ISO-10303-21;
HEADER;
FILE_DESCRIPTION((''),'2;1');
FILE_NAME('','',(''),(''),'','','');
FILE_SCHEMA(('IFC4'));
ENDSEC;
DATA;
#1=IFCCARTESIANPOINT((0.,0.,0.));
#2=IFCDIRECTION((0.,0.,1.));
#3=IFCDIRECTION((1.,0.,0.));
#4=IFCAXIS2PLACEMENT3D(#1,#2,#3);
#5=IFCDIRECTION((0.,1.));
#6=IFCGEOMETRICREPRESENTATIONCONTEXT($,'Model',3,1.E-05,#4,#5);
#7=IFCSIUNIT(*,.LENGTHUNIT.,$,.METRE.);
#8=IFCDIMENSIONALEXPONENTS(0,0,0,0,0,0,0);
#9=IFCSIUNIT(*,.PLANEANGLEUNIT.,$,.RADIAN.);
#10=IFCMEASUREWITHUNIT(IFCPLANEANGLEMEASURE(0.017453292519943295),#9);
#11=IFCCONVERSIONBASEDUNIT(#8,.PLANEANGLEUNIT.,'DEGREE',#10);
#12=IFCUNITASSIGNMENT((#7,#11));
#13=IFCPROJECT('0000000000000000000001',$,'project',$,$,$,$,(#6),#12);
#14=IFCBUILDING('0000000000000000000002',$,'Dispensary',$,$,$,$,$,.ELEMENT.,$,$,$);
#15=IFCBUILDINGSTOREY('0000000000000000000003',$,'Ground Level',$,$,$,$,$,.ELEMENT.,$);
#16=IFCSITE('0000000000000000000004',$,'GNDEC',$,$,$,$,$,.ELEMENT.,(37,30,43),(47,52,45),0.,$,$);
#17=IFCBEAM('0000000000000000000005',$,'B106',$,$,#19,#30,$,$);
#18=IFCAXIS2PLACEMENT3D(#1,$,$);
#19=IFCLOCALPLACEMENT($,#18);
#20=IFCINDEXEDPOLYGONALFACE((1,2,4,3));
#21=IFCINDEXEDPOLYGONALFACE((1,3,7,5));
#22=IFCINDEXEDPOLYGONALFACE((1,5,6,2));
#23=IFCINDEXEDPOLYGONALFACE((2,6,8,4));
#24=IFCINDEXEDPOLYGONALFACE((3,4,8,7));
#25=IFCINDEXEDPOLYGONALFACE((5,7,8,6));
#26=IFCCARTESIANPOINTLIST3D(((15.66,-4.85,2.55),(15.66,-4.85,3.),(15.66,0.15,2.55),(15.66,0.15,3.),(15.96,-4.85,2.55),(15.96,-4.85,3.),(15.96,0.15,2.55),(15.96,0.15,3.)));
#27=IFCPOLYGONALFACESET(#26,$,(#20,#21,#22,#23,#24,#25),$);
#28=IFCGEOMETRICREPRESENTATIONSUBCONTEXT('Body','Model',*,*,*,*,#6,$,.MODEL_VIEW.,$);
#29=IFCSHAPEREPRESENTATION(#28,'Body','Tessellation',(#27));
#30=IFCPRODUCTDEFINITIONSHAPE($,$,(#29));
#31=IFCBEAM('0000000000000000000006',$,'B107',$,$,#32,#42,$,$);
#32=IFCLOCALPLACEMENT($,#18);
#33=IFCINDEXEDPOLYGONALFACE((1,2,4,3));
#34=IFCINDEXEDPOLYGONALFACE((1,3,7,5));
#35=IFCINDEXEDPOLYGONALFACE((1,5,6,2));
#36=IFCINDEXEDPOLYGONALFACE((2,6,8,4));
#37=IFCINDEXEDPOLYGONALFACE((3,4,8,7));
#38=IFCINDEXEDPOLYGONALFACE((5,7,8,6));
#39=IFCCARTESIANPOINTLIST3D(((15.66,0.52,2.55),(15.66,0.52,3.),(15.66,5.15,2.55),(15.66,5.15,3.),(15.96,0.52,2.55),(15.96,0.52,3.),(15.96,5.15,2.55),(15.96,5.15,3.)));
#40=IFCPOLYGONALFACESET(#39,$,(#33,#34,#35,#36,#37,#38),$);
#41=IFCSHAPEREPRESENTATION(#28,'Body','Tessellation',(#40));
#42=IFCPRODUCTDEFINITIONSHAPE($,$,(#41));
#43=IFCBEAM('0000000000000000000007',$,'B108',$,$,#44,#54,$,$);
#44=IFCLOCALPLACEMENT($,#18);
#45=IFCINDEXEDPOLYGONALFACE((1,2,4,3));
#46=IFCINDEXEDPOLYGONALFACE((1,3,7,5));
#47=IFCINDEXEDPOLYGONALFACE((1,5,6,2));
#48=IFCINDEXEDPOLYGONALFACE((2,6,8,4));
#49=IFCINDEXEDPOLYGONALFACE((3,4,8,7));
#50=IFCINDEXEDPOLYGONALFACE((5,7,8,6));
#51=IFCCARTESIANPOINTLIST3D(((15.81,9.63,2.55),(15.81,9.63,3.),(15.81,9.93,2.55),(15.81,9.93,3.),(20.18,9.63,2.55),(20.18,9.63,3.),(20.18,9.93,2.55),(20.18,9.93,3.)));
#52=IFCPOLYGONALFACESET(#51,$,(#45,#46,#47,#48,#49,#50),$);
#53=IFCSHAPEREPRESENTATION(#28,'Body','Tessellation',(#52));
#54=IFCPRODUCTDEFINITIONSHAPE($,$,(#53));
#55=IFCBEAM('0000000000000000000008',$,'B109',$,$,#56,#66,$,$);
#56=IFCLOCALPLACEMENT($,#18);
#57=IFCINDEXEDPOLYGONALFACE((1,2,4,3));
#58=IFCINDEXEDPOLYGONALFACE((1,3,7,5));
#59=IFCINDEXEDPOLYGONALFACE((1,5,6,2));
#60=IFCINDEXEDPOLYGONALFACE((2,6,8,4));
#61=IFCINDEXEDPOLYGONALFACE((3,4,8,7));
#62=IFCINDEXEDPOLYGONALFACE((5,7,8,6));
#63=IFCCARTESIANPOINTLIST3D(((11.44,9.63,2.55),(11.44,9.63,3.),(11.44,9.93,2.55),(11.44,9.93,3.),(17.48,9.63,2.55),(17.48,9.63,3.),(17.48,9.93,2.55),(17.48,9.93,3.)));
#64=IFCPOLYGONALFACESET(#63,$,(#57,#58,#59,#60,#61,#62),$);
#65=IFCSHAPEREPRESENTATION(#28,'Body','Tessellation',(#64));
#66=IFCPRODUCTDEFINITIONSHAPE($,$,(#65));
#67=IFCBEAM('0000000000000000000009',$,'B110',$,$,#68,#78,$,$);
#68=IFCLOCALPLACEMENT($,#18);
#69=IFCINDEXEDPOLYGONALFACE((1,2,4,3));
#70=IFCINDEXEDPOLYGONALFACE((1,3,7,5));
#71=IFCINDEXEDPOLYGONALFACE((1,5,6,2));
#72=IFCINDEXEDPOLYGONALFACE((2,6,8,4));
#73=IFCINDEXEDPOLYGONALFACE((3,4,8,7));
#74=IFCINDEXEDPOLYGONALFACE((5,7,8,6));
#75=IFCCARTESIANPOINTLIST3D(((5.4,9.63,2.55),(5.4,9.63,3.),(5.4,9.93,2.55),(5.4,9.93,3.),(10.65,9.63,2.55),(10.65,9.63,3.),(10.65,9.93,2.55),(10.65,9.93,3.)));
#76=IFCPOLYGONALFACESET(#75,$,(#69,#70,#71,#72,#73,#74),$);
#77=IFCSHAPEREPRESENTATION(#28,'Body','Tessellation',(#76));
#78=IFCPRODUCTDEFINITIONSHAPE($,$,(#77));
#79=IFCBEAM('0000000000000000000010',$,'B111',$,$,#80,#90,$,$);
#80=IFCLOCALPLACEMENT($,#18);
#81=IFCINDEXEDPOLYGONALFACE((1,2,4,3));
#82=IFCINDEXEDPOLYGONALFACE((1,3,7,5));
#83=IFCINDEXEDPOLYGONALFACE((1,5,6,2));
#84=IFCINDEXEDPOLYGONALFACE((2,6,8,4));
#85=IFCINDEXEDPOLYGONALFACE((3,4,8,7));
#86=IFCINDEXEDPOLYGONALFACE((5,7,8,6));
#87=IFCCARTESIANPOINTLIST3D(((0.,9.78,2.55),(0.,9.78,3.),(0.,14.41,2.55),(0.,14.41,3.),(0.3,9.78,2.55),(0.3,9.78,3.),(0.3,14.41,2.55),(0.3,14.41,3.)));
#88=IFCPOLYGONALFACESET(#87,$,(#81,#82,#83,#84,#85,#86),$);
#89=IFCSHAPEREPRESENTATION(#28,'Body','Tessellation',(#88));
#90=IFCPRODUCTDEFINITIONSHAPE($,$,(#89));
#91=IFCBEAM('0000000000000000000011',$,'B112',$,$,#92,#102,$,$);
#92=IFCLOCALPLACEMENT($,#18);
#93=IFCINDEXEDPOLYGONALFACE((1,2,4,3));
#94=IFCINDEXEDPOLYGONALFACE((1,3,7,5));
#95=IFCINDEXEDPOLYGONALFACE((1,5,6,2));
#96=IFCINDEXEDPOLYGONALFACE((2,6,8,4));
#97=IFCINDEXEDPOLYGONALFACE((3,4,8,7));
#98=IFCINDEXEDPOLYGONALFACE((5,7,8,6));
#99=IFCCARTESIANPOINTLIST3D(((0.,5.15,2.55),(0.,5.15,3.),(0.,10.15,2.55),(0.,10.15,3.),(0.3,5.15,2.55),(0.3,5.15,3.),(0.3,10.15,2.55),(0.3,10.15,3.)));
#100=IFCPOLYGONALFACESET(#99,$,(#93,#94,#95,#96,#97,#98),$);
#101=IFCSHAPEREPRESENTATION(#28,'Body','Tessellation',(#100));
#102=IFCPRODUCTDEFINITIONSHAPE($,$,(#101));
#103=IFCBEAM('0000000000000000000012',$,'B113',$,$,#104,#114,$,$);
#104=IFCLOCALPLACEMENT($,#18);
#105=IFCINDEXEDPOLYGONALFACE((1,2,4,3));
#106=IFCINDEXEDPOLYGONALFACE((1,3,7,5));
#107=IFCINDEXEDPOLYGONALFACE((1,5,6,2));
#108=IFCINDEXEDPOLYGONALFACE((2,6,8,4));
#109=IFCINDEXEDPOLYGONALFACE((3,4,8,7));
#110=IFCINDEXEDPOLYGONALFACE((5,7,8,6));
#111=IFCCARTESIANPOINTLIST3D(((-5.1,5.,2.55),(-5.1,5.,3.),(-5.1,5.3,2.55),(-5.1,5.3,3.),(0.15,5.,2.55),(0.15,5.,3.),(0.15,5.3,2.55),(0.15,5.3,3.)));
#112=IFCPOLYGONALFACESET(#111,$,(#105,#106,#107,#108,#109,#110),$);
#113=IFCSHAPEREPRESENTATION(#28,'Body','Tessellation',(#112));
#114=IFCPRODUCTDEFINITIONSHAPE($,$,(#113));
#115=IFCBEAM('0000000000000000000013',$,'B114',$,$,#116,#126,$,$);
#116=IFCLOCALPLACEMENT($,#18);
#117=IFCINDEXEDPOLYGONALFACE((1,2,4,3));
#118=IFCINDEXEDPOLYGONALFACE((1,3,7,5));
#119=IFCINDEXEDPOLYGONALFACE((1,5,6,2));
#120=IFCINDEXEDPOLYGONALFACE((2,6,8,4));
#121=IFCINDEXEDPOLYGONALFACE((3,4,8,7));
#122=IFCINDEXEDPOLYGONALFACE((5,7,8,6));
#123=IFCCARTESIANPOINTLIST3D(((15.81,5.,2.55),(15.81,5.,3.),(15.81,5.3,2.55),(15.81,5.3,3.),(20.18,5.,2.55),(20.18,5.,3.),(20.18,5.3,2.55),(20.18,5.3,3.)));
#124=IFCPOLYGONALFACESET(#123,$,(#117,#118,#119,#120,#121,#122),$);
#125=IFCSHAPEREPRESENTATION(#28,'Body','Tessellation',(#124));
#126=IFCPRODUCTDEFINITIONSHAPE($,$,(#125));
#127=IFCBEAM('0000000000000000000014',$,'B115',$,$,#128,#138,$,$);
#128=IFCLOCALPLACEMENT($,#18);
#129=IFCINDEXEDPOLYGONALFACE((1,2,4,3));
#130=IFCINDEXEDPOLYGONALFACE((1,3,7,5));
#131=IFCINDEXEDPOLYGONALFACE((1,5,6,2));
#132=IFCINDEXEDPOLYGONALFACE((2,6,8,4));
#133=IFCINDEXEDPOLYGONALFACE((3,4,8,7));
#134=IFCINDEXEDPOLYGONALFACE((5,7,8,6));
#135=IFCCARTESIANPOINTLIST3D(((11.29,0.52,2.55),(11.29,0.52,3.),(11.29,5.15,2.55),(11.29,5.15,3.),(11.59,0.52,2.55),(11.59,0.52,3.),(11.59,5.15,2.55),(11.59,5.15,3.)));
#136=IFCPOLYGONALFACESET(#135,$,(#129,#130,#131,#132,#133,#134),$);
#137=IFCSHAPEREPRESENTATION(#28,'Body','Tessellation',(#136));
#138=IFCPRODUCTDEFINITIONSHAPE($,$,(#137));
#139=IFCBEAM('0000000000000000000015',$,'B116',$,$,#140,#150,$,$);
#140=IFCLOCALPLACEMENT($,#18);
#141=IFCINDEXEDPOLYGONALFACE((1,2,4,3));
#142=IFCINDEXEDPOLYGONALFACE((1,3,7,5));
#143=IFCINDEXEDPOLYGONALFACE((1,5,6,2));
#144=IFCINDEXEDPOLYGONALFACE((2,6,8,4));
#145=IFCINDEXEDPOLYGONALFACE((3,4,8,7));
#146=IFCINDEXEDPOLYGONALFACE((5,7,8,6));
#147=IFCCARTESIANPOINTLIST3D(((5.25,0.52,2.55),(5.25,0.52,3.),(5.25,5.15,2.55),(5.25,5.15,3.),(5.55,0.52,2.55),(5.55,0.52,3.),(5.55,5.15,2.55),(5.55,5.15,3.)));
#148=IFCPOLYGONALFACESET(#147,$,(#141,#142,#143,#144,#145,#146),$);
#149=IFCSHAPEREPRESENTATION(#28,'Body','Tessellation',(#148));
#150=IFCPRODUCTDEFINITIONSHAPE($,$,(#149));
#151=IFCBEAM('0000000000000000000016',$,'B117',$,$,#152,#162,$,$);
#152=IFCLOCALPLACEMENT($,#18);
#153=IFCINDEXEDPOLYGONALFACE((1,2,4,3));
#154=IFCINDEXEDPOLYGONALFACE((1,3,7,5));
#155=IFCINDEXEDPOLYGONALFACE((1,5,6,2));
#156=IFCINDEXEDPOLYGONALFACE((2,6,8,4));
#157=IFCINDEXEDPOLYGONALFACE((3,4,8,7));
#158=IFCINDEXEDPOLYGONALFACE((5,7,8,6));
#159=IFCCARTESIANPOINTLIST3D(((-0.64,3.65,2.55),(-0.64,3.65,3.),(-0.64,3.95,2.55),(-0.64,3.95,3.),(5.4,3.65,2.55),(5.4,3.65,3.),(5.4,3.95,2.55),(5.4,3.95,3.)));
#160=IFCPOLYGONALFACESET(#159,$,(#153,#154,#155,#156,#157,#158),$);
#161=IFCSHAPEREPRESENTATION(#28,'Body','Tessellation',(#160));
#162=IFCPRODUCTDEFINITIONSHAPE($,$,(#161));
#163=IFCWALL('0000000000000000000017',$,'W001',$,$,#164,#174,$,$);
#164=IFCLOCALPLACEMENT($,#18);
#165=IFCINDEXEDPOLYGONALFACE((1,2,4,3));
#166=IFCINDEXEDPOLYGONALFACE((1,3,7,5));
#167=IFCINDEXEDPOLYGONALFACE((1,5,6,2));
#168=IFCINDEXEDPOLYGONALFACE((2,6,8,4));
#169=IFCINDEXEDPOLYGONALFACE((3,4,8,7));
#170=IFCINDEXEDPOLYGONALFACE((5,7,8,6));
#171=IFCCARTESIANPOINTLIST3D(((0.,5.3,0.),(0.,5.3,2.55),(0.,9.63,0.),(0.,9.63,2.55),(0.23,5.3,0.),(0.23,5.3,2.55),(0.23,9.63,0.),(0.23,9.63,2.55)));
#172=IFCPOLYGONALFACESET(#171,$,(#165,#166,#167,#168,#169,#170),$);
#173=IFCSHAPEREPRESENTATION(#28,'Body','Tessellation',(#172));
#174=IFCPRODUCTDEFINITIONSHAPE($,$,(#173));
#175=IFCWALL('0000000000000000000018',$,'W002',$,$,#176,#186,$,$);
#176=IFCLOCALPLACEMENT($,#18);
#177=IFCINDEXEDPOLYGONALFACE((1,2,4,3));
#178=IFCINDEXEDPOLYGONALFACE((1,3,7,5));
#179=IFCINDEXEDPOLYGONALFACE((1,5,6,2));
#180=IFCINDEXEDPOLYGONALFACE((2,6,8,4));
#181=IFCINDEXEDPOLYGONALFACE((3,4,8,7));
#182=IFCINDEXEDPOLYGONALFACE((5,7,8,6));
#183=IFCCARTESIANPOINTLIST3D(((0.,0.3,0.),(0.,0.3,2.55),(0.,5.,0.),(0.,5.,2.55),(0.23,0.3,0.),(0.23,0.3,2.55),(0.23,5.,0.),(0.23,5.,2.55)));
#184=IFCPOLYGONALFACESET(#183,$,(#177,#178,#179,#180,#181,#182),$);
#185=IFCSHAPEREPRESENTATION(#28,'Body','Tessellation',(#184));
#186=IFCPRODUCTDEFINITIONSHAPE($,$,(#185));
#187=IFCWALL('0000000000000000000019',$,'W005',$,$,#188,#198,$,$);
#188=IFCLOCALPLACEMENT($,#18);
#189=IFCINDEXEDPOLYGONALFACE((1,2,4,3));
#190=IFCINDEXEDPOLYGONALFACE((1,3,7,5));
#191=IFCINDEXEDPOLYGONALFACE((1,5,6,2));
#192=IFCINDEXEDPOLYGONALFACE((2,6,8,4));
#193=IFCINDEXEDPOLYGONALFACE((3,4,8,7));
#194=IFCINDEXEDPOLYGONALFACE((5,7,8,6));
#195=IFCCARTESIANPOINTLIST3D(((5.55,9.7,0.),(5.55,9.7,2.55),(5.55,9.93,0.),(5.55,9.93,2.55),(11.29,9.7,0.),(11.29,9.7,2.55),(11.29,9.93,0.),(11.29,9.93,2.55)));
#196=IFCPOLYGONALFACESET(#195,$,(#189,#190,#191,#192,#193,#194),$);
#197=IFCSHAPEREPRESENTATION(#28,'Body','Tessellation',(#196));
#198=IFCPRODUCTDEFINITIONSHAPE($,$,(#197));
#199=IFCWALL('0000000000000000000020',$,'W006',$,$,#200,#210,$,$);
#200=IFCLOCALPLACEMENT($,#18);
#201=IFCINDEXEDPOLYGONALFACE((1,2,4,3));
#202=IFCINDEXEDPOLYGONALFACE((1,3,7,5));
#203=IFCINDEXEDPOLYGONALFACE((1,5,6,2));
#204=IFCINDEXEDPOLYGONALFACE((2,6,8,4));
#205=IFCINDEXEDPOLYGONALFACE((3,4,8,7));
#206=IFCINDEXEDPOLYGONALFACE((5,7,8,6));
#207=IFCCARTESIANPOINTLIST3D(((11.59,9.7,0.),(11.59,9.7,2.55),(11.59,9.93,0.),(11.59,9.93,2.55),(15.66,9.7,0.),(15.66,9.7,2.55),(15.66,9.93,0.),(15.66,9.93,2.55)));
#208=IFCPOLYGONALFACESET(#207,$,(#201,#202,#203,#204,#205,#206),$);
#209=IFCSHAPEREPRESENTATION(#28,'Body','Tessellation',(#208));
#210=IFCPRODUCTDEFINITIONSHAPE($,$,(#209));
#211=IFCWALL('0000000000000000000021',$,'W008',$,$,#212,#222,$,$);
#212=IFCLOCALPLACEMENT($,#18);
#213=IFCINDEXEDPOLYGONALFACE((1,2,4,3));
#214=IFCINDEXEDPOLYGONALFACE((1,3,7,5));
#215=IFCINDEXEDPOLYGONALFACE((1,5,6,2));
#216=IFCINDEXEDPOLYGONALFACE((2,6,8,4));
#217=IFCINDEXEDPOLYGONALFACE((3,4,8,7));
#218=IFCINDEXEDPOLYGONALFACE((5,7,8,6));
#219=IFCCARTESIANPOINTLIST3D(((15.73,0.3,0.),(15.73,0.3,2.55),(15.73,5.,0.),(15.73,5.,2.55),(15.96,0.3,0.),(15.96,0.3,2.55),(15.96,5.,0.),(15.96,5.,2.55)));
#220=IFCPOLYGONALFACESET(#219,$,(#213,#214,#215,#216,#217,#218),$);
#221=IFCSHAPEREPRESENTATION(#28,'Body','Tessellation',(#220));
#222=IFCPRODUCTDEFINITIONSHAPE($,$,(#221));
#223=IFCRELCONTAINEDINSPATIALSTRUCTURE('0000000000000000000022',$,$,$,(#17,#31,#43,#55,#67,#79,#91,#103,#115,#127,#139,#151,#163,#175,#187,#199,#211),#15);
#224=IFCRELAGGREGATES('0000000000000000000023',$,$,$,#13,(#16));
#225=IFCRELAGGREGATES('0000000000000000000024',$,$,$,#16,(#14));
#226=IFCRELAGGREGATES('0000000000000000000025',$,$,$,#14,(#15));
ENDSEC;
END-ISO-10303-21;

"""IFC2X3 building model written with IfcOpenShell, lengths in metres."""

from ifc_helpers import new_model, entity, si_unit, converted_unit, direction, frame, frame_2d, origin_with_axes, place, context, subcontext, project, spatial, rectangle, extrude, element, save


model = new_model("IFC2X3")

# Units and contexts
model_context = context("Model", 3, precision=1e-05, world=origin_with_axes(), true_north=direction((0.0, 1.0)))
body_context = subcontext(model_context, "Body", "Model", "MODEL_VIEW")
ifc_project = project(units=[si_unit("LENGTHUNIT", "METRE"), converted_unit("PLANEANGLEUNIT", "DEGREE", entity("IfcPlaneAngleMeasure", 0.017453292519943295), si_unit("PLANEANGLEUNIT", "RADIAN"), dimensions=[0, 0, 0, 0, 0, 0, 0])], contexts=[model_context])

# Site, building, storey
site = spatial("IfcSite", under=ifc_project, Name="GNDEC", CompositionType="ELEMENT", RefLatitude=(37, 30, 43), RefLongitude=(47, 52, 45), RefElevation=0.0)
building = spatial("IfcBuilding", under=site, Name="Dispensary", CompositionType="ELEMENT")
storey = spatial("IfcBuildingStorey", under=building, Name="Ground Level", CompositionType="ELEMENT")

# Shared definitions
placement = place(None, origin_with_axes())

# Beams
element("IfcBeam", 1, at=placement, inside=storey, Name="B106", context=body_context, shape_type="SweptSolid", body=[
    extrude(rectangle(XDim=0.3, YDim=0.45, at=frame_2d((0.0, 0.0), x_axis=(0.0, 1.0))), frame((15.81, 0.15, 2.775), z_axis=(0.0, -1.0, 0.0), x_axis=(0.0, 0.0, 1.0)), (0.0, 0.0, 1.0), 5.0),
])
element("IfcBeam", 2, at=placement, inside=storey, Name="B107", context=body_context, shape_type="SweptSolid", body=[
    extrude(rectangle(XDim=0.3, YDim=0.45, at=frame_2d((0.0, 0.0), x_axis=(0.0, 1.0))), frame((15.81, 5.15, 2.775), z_axis=(0.0, -1.0, 0.0), x_axis=(0.0, 0.0, 1.0)), (0.0, 0.0, 1.0), 4.63),
])
element("IfcBeam", 3, at=placement, inside=storey, Name="B108", context=body_context, shape_type="SweptSolid", body=[
    extrude(rectangle(XDim=0.3, YDim=0.45, at=frame_2d((0.0, 0.0), x_axis=(0.0, 1.0))), frame((15.81, 9.78, 2.775), z_axis=(1.0, 0.0, 0.0), x_axis=(0.0, 0.0, 1.0)), (0.0, 0.0, 1.0), 4.37),
])
element("IfcBeam", 4, at=placement, inside=storey, Name="B109", context=body_context, shape_type="SweptSolid", body=[
    extrude(rectangle(XDim=0.3, YDim=0.45, at=frame_2d((0.0, 0.0), x_axis=(0.0, 1.0))), frame((11.44, 9.78, 2.775), z_axis=(1.0, 0.0, 0.0), x_axis=(0.0, 0.0, 1.0)), (0.0, 0.0, 1.0), 6.04),
])
element("IfcBeam", 5, at=placement, inside=storey, Name="B110", context=body_context, shape_type="SweptSolid", body=[
    extrude(rectangle(XDim=0.3, YDim=0.45, at=frame_2d((0.0, 0.0), x_axis=(0.0, 1.0))), frame((5.4, 9.78, 2.775), z_axis=(1.0, 0.0, 0.0), x_axis=(0.0, 0.0, 1.0)), (0.0, 0.0, 1.0), 5.25),
])
element("IfcBeam", 6, at=placement, inside=storey, Name="B111", context=body_context, shape_type="SweptSolid", body=[
    extrude(rectangle(XDim=0.3, YDim=0.45, at=frame_2d((0.0, 0.0), x_axis=(0.0, 1.0))), frame((0.15, 9.78, 2.775), z_axis=(0.0, 1.0, 0.0), x_axis=(0.0, 0.0, 1.0)), (0.0, 0.0, 1.0), 4.63),
])
element("IfcBeam", 7, at=placement, inside=storey, Name="B112", context=body_context, shape_type="SweptSolid", body=[
    extrude(rectangle(XDim=0.3, YDim=0.45, at=frame_2d((0.0, 0.0), x_axis=(0.0, 1.0))), frame((0.15, 5.15, 2.775), z_axis=(0.0, 1.0, 0.0), x_axis=(0.0, 0.0, 1.0)), (0.0, 0.0, 1.0), 5.0),
])
element("IfcBeam", 8, at=placement, inside=storey, Name="B113", context=body_context, shape_type="SweptSolid", body=[
    extrude(rectangle(XDim=0.3, YDim=0.45, at=frame_2d((0.0, 0.0), x_axis=(0.0, 1.0))), frame((0.15, 5.15, 2.775), z_axis=(-1.0, 0.0, 0.0), x_axis=(0.0, 0.0, 1.0)), (0.0, 0.0, 1.0), 5.25),
])
element("IfcBeam", 9, at=placement, inside=storey, Name="B114", context=body_context, shape_type="SweptSolid", body=[
    extrude(rectangle(XDim=0.3, YDim=0.45, at=frame_2d((0.0, 0.0), x_axis=(0.0, 1.0))), frame((15.81, 5.15, 2.775), z_axis=(1.0, 0.0, 0.0), x_axis=(0.0, 0.0, 1.0)), (0.0, 0.0, 1.0), 4.37),
])
element("IfcBeam", 10, at=placement, inside=storey, Name="B115", context=body_context, shape_type="SweptSolid", body=[
    extrude(rectangle(XDim=0.3, YDim=0.45, at=frame_2d((0.0, 0.0), x_axis=(0.0, 1.0))), frame((11.44, 5.15, 2.775), z_axis=(0.0, -1.0, 0.0), x_axis=(0.0, 0.0, 1.0)), (0.0, 0.0, 1.0), 4.63),
])
element("IfcBeam", 11, at=placement, inside=storey, Name="B116", context=body_context, shape_type="SweptSolid", body=[
    extrude(rectangle(XDim=0.3, YDim=0.45, at=frame_2d((0.0, 0.0), x_axis=(0.0, 1.0))), frame((5.4, 5.15, 2.775), z_axis=(0.0, -1.0, 0.0), x_axis=(0.0, 0.0, 1.0)), (0.0, 0.0, 1.0), 4.63),
])
element("IfcBeam", 12, at=placement, inside=storey, Name="B117", context=body_context, shape_type="SweptSolid", body=[
    extrude(rectangle(XDim=0.3, YDim=0.45, at=frame_2d((0.0, 0.0), x_axis=(0.0, 1.0))), frame((5.4, 3.8, 2.775), z_axis=(-1.0, 0.0, 0.0), x_axis=(0.0, 0.0, 1.0)), (0.0, 0.0, 1.0), 6.04),
])

# Walls
element("IfcWall", 13, at=placement, inside=storey, Name="W001", context=body_context, shape_type="SweptSolid", body=[
    extrude(rectangle(XDim=4.33, YDim=0.23, at=frame_2d((0.0, 0.0), x_axis=(0.0, -1.0))), frame((0.115, 7.465, 0.0), z_axis=(0.0, 0.0, 1.0), x_axis=(1.0, 0.0, 0.0)), (0.0, 0.0, 1.0), 2.55),
])
element("IfcWall", 14, at=placement, inside=storey, Name="W002", context=body_context, shape_type="SweptSolid", body=[
    extrude(rectangle(XDim=4.7, YDim=0.23, at=frame_2d((0.0, 0.0), x_axis=(0.0, -1.0))), frame((0.115, 2.65, 0.0), z_axis=(0.0, 0.0, 1.0), x_axis=(1.0, 0.0, 0.0)), (0.0, 0.0, 1.0), 2.55),
])
element("IfcWall", 15, at=placement, inside=storey, Name="W005", context=body_context, shape_type="SweptSolid", body=[
    extrude(rectangle(XDim=5.74, YDim=0.23, at=frame_2d((0.0, 0.0), x_axis=(-1.0, 0.0))), frame((8.42, 9.815, 0.0), z_axis=(0.0, 0.0, 1.0), x_axis=(1.0, 0.0, 0.0)), (0.0, 0.0, 1.0), 2.55),
])
element("IfcWall", 16, at=placement, inside=storey, Name="W006", context=body_context, shape_type="SweptSolid", body=[
    extrude(rectangle(XDim=4.07, YDim=0.23, at=frame_2d((0.0, 0.0), x_axis=(-1.0, 0.0))), frame((13.625, 9.815, 0.0), z_axis=(0.0, 0.0, 1.0), x_axis=(1.0, 0.0, 0.0)), (0.0, 0.0, 1.0), 2.55),
])
element("IfcWall", 17, at=placement, inside=storey, Name="W008", context=body_context, shape_type="SweptSolid", body=[
    extrude(rectangle(XDim=4.7, YDim=0.23, at=frame_2d((0.0, 0.0), x_axis=(0.0, 1.0))), frame((15.845, 2.65, 0.0), z_axis=(0.0, 0.0, 1.0), x_axis=(1.0, 0.0, 0.0)), (0.0, 0.0, 1.0), 2.55),
])

save(model, "model.ifc")
